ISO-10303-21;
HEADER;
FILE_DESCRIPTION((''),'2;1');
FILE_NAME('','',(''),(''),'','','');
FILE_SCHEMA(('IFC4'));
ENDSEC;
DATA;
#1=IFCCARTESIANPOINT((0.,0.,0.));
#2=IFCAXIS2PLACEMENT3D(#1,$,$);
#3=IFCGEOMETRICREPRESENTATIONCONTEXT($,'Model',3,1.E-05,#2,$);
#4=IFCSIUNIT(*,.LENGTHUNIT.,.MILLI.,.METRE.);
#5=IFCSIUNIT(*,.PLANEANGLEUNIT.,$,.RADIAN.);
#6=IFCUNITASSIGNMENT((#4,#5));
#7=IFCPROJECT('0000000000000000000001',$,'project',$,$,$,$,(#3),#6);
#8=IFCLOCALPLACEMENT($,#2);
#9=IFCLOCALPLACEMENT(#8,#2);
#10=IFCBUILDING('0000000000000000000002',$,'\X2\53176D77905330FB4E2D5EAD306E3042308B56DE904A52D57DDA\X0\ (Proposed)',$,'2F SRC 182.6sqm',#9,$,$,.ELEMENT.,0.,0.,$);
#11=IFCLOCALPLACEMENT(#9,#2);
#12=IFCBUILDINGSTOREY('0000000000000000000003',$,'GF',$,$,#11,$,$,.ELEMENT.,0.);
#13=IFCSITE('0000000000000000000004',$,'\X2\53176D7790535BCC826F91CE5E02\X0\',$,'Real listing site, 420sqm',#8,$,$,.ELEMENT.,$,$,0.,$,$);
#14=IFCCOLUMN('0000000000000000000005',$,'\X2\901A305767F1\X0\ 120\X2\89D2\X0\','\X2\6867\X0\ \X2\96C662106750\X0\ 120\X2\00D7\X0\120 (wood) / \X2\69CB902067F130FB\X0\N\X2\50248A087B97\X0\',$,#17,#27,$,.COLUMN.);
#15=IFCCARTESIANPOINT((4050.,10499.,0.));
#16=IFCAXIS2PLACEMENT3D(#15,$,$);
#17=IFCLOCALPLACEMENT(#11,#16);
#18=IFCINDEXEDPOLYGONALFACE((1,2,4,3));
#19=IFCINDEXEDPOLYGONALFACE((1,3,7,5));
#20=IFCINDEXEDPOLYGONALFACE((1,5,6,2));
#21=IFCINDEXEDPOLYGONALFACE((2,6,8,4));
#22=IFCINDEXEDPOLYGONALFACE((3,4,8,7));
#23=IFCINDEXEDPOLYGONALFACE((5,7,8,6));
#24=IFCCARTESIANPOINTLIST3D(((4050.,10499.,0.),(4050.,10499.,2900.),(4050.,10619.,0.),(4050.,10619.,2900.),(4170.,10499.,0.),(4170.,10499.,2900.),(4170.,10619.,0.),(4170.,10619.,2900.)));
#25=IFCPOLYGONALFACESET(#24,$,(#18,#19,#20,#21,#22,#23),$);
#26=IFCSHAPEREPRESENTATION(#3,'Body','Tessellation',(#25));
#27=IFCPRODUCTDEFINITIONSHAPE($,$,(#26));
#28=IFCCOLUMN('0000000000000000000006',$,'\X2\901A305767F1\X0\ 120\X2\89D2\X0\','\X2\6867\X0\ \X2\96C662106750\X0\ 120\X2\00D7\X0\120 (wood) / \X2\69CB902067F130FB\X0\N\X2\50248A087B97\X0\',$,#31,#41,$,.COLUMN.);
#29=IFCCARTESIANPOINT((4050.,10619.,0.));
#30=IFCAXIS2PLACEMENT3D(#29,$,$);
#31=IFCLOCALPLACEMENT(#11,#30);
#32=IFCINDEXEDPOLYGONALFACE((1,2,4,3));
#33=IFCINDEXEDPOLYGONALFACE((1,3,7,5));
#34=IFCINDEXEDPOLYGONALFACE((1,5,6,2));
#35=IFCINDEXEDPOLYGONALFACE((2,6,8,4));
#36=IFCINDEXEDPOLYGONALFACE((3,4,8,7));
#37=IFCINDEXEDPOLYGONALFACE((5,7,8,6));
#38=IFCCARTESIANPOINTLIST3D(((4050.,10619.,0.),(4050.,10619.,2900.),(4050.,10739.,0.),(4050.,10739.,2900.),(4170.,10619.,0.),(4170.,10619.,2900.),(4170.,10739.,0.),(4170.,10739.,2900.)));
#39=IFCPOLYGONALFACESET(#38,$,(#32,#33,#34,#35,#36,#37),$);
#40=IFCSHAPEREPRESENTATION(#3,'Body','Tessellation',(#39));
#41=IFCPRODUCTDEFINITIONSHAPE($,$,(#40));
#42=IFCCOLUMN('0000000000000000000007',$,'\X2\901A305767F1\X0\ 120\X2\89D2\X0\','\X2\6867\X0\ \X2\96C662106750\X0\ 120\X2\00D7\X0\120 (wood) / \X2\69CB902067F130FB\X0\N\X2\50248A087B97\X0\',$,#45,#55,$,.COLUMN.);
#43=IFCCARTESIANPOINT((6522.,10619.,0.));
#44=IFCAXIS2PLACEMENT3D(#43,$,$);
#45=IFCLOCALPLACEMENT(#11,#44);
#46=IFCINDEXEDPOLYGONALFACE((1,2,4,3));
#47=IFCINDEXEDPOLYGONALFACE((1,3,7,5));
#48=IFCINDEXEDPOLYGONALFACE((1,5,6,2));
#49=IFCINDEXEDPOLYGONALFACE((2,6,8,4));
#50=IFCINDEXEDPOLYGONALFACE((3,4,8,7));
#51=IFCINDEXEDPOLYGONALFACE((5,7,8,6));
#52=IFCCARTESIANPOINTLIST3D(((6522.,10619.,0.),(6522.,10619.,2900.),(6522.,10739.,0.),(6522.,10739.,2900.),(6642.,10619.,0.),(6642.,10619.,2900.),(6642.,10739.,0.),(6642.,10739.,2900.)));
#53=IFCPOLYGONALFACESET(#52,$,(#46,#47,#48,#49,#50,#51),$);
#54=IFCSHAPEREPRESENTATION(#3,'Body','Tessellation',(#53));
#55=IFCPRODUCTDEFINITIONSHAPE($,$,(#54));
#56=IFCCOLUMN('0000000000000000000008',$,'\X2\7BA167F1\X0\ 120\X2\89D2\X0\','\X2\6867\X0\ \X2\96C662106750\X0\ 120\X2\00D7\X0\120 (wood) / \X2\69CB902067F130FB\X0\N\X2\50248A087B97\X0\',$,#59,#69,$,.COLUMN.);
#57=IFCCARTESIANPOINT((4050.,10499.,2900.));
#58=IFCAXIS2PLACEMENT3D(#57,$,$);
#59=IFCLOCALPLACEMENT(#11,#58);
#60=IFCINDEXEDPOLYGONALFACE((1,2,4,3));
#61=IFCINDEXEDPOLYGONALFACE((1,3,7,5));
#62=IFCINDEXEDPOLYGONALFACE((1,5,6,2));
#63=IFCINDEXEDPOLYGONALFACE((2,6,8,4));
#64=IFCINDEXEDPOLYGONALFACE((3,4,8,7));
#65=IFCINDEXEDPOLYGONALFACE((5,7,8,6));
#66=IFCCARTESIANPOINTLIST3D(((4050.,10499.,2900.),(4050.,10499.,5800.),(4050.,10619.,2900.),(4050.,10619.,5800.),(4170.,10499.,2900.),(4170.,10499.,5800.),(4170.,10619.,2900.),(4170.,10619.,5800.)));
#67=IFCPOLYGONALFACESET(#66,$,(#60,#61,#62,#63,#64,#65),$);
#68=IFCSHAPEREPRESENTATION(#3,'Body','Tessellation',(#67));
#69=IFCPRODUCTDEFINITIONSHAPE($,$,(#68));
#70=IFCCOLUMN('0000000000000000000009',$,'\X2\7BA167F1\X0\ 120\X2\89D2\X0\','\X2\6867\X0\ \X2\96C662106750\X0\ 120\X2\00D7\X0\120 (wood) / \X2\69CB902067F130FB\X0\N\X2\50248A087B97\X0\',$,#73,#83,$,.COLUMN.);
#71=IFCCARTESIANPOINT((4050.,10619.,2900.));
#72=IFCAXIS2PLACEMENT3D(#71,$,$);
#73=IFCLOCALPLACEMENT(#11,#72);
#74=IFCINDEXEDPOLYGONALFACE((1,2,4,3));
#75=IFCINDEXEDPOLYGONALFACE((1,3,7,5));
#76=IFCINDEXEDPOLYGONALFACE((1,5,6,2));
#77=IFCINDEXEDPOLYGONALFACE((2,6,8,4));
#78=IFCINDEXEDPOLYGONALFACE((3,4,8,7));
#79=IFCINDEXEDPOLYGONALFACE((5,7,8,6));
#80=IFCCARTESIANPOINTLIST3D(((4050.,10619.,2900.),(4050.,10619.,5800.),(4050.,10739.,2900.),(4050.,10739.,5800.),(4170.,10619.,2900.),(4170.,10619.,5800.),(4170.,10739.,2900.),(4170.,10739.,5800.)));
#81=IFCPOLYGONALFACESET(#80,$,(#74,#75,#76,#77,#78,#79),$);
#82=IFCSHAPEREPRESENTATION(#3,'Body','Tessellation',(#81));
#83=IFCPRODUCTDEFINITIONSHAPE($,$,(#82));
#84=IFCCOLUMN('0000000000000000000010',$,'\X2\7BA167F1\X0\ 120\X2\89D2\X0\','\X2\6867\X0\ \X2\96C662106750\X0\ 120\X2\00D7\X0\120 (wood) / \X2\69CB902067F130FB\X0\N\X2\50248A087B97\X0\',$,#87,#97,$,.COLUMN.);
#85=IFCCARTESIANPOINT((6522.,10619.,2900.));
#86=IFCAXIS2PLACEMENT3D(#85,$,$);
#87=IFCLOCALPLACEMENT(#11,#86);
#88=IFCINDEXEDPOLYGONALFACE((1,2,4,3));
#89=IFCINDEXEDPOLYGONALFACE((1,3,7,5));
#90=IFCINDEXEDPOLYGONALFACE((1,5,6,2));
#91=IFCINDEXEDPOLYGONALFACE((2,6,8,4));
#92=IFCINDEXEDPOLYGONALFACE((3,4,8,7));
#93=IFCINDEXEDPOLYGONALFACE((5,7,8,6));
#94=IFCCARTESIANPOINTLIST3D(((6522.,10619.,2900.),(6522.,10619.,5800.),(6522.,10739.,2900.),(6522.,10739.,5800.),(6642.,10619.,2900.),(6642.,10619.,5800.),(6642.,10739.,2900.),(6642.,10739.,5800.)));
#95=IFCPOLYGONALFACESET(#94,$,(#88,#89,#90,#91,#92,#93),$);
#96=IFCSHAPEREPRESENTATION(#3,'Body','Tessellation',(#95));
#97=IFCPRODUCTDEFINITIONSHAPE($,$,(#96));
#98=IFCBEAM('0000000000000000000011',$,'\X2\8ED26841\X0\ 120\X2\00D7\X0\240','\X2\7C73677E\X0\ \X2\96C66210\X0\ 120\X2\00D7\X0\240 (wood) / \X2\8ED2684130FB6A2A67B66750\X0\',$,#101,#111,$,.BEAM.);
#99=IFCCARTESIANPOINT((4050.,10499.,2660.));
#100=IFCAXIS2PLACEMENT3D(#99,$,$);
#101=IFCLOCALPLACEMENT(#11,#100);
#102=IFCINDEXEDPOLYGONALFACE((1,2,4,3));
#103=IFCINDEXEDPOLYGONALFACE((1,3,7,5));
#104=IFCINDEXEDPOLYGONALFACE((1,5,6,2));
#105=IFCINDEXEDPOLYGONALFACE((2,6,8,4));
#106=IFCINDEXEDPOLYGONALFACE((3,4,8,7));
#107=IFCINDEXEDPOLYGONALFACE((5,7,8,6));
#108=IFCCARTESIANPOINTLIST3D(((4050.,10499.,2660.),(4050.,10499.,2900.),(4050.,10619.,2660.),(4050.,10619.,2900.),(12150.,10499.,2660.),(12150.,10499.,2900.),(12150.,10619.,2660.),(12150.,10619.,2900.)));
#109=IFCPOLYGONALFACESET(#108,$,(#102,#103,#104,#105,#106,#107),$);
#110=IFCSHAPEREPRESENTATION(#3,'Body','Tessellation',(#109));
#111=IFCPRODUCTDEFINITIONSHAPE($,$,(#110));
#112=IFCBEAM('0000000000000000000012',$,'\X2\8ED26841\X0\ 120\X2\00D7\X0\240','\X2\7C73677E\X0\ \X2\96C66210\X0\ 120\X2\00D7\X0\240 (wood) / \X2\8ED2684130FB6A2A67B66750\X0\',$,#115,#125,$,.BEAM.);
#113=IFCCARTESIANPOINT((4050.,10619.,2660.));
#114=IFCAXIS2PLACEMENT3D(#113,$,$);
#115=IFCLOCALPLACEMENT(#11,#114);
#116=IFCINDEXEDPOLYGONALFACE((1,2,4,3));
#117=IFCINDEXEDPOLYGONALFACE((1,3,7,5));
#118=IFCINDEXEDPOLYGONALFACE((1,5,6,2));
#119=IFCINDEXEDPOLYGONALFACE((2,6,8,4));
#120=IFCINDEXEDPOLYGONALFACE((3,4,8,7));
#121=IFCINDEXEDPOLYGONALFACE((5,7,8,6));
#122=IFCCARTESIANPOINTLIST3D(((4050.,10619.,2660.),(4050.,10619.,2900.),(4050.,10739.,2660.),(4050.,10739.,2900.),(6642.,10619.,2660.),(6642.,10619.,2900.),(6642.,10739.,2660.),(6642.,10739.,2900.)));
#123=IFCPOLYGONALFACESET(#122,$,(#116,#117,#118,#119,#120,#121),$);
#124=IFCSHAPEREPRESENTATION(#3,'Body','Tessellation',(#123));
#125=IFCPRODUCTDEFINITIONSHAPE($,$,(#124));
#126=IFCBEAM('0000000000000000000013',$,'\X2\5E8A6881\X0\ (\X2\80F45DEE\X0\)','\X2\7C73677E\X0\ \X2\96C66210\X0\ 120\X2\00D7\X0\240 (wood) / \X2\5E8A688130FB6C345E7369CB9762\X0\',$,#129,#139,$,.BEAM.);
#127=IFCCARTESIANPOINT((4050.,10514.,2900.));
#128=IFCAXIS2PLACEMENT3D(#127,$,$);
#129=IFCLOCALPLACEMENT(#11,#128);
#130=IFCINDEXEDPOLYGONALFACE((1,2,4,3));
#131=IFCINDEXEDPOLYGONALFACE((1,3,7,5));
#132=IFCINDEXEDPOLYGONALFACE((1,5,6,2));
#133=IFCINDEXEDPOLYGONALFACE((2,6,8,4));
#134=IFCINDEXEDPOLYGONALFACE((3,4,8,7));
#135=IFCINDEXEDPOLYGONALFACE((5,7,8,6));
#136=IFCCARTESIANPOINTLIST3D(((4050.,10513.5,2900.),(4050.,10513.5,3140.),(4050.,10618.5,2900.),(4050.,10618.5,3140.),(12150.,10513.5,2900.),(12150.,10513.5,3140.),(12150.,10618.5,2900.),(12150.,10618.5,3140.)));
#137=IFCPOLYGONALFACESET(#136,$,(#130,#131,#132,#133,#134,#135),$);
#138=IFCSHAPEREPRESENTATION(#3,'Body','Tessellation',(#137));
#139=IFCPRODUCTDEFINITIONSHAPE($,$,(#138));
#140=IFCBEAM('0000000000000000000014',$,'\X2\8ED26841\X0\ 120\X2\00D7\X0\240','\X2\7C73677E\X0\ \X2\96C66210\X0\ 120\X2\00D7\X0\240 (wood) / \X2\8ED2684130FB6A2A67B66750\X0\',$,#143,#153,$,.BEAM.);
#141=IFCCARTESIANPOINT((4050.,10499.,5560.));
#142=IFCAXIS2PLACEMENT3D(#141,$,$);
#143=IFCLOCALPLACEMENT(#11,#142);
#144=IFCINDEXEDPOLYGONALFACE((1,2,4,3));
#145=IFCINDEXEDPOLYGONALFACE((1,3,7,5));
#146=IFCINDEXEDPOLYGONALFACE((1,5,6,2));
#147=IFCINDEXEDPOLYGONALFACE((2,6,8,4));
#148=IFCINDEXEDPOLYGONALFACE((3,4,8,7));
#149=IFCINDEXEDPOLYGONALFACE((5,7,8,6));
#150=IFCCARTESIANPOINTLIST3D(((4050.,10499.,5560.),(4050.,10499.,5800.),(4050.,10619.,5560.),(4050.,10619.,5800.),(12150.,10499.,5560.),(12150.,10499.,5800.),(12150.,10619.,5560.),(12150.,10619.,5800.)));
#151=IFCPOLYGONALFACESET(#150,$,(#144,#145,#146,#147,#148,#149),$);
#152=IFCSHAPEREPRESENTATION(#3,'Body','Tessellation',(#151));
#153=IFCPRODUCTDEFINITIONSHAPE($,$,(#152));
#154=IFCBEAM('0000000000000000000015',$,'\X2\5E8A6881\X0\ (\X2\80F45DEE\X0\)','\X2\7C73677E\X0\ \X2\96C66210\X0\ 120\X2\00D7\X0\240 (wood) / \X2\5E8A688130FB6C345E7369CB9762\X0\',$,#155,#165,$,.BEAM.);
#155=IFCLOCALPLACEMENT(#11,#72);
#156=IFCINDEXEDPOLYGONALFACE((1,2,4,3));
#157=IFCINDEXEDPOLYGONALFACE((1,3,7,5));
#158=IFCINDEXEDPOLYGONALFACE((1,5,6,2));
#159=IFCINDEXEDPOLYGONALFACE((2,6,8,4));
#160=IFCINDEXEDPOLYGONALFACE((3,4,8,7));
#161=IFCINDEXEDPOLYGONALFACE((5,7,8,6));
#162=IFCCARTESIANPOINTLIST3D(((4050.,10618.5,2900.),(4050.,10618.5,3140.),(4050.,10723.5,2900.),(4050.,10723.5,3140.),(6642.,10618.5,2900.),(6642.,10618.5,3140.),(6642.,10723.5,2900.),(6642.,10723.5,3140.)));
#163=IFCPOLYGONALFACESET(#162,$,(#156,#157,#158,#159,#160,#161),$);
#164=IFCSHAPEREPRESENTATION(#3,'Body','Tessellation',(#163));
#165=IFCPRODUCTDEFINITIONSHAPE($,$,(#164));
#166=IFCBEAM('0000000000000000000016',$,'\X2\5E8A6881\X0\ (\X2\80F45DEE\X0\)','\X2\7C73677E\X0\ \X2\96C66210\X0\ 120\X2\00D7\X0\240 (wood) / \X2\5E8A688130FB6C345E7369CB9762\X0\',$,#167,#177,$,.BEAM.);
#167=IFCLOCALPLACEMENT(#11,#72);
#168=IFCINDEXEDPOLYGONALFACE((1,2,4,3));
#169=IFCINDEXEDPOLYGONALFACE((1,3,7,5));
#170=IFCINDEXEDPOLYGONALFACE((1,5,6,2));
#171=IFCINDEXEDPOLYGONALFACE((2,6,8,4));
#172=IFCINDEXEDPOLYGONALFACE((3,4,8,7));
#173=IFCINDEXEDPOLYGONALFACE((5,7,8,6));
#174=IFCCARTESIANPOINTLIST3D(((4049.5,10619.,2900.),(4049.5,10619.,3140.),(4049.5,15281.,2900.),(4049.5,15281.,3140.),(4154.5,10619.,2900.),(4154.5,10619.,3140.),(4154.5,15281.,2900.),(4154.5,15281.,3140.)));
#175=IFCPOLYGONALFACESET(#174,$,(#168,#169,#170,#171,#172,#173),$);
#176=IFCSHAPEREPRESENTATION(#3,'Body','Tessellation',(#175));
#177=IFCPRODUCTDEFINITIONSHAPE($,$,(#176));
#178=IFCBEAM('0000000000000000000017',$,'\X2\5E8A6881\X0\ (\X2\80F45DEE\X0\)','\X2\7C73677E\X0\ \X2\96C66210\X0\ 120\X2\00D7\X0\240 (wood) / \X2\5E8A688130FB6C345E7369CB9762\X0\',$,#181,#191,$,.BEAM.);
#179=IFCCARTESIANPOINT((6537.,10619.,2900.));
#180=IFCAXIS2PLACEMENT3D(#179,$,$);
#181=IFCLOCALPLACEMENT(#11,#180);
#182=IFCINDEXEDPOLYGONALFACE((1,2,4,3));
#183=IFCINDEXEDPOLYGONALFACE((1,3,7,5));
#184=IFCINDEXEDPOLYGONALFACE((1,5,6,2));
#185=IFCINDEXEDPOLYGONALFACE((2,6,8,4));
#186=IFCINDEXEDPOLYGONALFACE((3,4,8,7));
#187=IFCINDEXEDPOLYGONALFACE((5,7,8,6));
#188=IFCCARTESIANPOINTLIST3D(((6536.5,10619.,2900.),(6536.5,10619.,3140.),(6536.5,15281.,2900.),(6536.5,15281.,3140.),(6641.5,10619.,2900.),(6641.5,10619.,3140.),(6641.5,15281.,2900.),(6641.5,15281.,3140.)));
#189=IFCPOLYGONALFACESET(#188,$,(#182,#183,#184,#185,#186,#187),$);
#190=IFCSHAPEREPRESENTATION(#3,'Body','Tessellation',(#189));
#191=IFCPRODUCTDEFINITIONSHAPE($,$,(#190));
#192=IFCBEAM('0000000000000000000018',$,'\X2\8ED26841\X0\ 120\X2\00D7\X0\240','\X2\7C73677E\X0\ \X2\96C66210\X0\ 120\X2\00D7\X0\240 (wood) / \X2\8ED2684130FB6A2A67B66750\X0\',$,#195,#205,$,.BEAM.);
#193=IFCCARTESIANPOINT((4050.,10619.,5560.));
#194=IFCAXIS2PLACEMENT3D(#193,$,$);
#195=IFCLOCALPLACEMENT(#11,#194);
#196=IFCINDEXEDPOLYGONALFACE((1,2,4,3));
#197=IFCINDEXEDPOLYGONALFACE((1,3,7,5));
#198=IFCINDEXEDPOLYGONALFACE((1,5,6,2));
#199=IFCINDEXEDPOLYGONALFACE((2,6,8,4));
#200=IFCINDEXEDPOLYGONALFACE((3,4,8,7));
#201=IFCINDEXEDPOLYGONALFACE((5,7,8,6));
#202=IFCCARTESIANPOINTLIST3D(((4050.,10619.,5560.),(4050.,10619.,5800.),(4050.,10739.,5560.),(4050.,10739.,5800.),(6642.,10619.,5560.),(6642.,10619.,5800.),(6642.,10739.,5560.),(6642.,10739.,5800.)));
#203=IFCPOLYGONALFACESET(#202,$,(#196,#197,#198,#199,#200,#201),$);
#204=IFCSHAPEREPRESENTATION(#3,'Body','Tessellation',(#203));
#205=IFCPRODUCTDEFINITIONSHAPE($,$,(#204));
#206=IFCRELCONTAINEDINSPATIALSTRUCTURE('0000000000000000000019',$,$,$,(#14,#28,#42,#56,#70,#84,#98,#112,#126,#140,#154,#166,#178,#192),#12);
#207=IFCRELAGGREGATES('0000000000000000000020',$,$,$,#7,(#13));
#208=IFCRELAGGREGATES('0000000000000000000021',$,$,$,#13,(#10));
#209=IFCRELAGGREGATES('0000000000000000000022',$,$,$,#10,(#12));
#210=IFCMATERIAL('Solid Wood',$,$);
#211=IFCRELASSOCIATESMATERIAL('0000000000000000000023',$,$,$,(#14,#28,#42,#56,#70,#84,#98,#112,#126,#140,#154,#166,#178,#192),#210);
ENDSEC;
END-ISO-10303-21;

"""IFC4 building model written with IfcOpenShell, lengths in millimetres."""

from ifc_helpers import new_model, si_unit, frame, frame_2d, origin, place, context, project, spatial, rectangle, extrude, material, element, save


model = new_model("IFC4")

# Units and contexts
model_context = context("Model", 3, precision=1e-05, world=origin())
ifc_project = project(units=[si_unit("LENGTHUNIT", "METRE", prefix="MILLI"), si_unit("PLANEANGLEUNIT", "RADIAN")], contexts=[model_context])

# Site, building, storey
site_placement = place(None, origin())
site = spatial("IfcSite", under=ifc_project, at=site_placement, Name="北海道富良野市", ObjectType="Real listing site, 420sqm", CompositionType="ELEMENT", RefElevation=0.0)
building_placement = place(site_placement, origin())
building = spatial("IfcBuilding", under=site, at=building_placement, Name="北海道・中庭のある回遊動線 (Proposed)", ObjectType="2F SRC 182.6sqm", CompositionType="ELEMENT", ElevationOfRefHeight=0.0, ElevationOfTerrain=0.0)
storey_placement = place(building_placement, origin())
storey = spatial("IfcBuildingStorey", under=building, at=storey_placement, Name="GF", CompositionType="ELEMENT", Elevation=0.0)

# Columns
ifc_material_1 = material(Name="Solid Wood")
column_1_placement = place(storey_placement, frame((4050.0, 10499.0, 0.0)))
element("IfcColumn", 1, at=column_1_placement, inside=storey, material=ifc_material_1, Name="通し柱 120角", Description="桧 集成材 120×120 (wood) / 構造柱・N値計算", PredefinedType="COLUMN", context=model_context, shape_type="SweptSolid", body=[
    extrude(rectangle(XDim=120.0, YDim=120.0, at=frame_2d((60.0, 60.0))), frame((4050.0, 10499.0, 0.0)), (0.0, 0.0, 1.0), 2900.0),
])
column_2_placement = place(storey_placement, frame((4050.0, 10619.0, 0.0)))
element("IfcColumn", 2, at=column_2_placement, inside=storey, material=ifc_material_1, Name="通し柱 120角", Description="桧 集成材 120×120 (wood) / 構造柱・N値計算", PredefinedType="COLUMN", context=model_context, shape_type="SweptSolid", body=[
    extrude(rectangle(XDim=120.0, YDim=120.0, at=frame_2d((60.0, 60.0))), frame((4050.0, 10619.0, 0.0)), (0.0, 0.0, 1.0), 2900.0),
])
column_3_placement = place(storey_placement, frame((6522.0, 10619.0, 0.0)))
element("IfcColumn", 3, at=column_3_placement, inside=storey, material=ifc_material_1, Name="通し柱 120角", Description="桧 集成材 120×120 (wood) / 構造柱・N値計算", PredefinedType="COLUMN", context=model_context, shape_type="SweptSolid", body=[
    extrude(rectangle(XDim=120.0, YDim=120.0, at=frame_2d((60.0, 60.0))), frame((6522.0, 10619.0, 0.0)), (0.0, 0.0, 1.0), 2900.0),
])
column_4_placement = place(storey_placement, frame((4050.0, 10499.0, 2900.0)))
element("IfcColumn", 4, at=column_4_placement, inside=storey, material=ifc_material_1, Name="管柱 120角", Description="桧 集成材 120×120 (wood) / 構造柱・N値計算", PredefinedType="COLUMN", context=model_context, shape_type="SweptSolid", body=[
    extrude(rectangle(XDim=120.0, YDim=120.0, at=frame_2d((60.0, 60.0))), frame((4050.0, 10499.0, 2900.0)), (0.0, 0.0, 1.0), 2900.0),
])
column_5_placement = place(storey_placement, frame((4050.0, 10619.0, 2900.0)))
element("IfcColumn", 5, at=column_5_placement, inside=storey, material=ifc_material_1, Name="管柱 120角", Description="桧 集成材 120×120 (wood) / 構造柱・N値計算", PredefinedType="COLUMN", context=model_context, shape_type="SweptSolid", body=[
    extrude(rectangle(XDim=120.0, YDim=120.0, at=frame_2d((60.0, 60.0))), frame((4050.0, 10619.0, 2900.0)), (0.0, 0.0, 1.0), 2900.0),
])
column_6_placement = place(storey_placement, frame((6522.0, 10619.0, 2900.0)))
element("IfcColumn", 6, at=column_6_placement, inside=storey, material=ifc_material_1, Name="管柱 120角", Description="桧 集成材 120×120 (wood) / 構造柱・N値計算", PredefinedType="COLUMN", context=model_context, shape_type="SweptSolid", body=[
    extrude(rectangle(XDim=120.0, YDim=120.0, at=frame_2d((60.0, 60.0))), frame((6522.0, 10619.0, 2900.0)), (0.0, 0.0, 1.0), 2900.0),
])

# Beams
beam_1_placement = place(storey_placement, frame((4050.0, 10499.0, 2660.0)))
element("IfcBeam", 7, at=beam_1_placement, inside=storey, material=ifc_material_1, Name="軒桁 120×240", Description="米松 集成 120×240 (wood) / 軒桁・横架材", PredefinedType="BEAM", context=model_context, shape_type="SweptSolid", body=[
    extrude(rectangle(XDim=8100.0, YDim=120.0, at=frame_2d((4050.0, 60.0))), frame((4050.0, 10499.0, 2660.0)), (0.0, 0.0, 1.0), 240.0),
])
beam_2_placement = place(storey_placement, frame((4050.0, 10619.0, 2660.0)))
element("IfcBeam", 8, at=beam_2_placement, inside=storey, material=ifc_material_1, Name="軒桁 120×240", Description="米松 集成 120×240 (wood) / 軒桁・横架材", PredefinedType="BEAM", context=model_context, shape_type="SweptSolid", body=[
    extrude(rectangle(XDim=2592.0, YDim=120.0, at=frame_2d((1296.0, 60.0))), frame((4050.0, 10619.0, 2660.0)), (0.0, 0.0, 1.0), 240.0),
])
beam_3_placement = place(storey_placement, frame((4050.0, 10514.0, 2900.0)))
element("IfcBeam", 9, at=beam_3_placement, inside=storey, material=ifc_material_1, Name="床梁 (胴差)", Description="米松 集成 120×240 (wood) / 床梁・水平構面", PredefinedType="BEAM", context=model_context, shape_type="SweptSolid", body=[
    extrude(rectangle(XDim=8100.0, YDim=105.0, at=frame_2d((4050.0, 52.0))), frame((4050.0, 10514.0, 2900.0)), (0.0, 0.0, 1.0), 240.0),
])
beam_4_placement = place(storey_placement, frame((4050.0, 10499.0, 5560.0)))
element("IfcBeam", 10, at=beam_4_placement, inside=storey, material=ifc_material_1, Name="軒桁 120×240", Description="米松 集成 120×240 (wood) / 軒桁・横架材", PredefinedType="BEAM", context=model_context, shape_type="SweptSolid", body=[
    extrude(rectangle(XDim=8100.0, YDim=120.0, at=frame_2d((4050.0, 60.0))), frame((4050.0, 10499.0, 5560.0)), (0.0, 0.0, 1.0), 240.0),
])
beam_5_placement = place(storey_placement, frame((4050.0, 10619.0, 2900.0)))
element("IfcBeam", 11, at=beam_5_placement, inside=storey, material=ifc_material_1, Name="床梁 (胴差)", Description="米松 集成 120×240 (wood) / 床梁・水平構面", PredefinedType="BEAM", context=model_context, shape_type="SweptSolid", body=[
    extrude(rectangle(XDim=2592.0, YDim=105.0, at=frame_2d((1296.0, 52.0))), frame((4050.0, 10619.0, 2900.0)), (0.0, 0.0, 1.0), 240.0),
])
beam_6_placement = place(storey_placement, frame((4050.0, 10619.0, 2900.0)))
element("IfcBeam", 12, at=beam_6_placement, inside=storey, material=ifc_material_1, Name="床梁 (胴差)", Description="米松 集成 120×240 (wood) / 床梁・水平構面", PredefinedType="BEAM", context=model_context, shape_type="SweptSolid", body=[
    extrude(rectangle(XDim=105.0, YDim=4662.0, at=frame_2d((52.0, 2331.0))), frame((4050.0, 10619.0, 2900.0)), (0.0, 0.0, 1.0), 240.0),
])
beam_7_placement = place(storey_placement, frame((6537.0, 10619.0, 2900.0)))
element("IfcBeam", 13, at=beam_7_placement, inside=storey, material=ifc_material_1, Name="床梁 (胴差)", Description="米松 集成 120×240 (wood) / 床梁・水平構面", PredefinedType="BEAM", context=model_context, shape_type="SweptSolid", body=[
    extrude(rectangle(XDim=105.0, YDim=4662.0, at=frame_2d((52.0, 2331.0))), frame((6537.0, 10619.0, 2900.0)), (0.0, 0.0, 1.0), 240.0),
])
beam_8_placement = place(storey_placement, frame((4050.0, 10619.0, 5560.0)))
element("IfcBeam", 14, at=beam_8_placement, inside=storey, material=ifc_material_1, Name="軒桁 120×240", Description="米松 集成 120×240 (wood) / 軒桁・横架材", PredefinedType="BEAM", context=model_context, shape_type="SweptSolid", body=[
    extrude(rectangle(XDim=2592.0, YDim=120.0, at=frame_2d((1296.0, 60.0))), frame((4050.0, 10619.0, 5560.0)), (0.0, 0.0, 1.0), 240.0),
])

save(model, "model.ifc")
